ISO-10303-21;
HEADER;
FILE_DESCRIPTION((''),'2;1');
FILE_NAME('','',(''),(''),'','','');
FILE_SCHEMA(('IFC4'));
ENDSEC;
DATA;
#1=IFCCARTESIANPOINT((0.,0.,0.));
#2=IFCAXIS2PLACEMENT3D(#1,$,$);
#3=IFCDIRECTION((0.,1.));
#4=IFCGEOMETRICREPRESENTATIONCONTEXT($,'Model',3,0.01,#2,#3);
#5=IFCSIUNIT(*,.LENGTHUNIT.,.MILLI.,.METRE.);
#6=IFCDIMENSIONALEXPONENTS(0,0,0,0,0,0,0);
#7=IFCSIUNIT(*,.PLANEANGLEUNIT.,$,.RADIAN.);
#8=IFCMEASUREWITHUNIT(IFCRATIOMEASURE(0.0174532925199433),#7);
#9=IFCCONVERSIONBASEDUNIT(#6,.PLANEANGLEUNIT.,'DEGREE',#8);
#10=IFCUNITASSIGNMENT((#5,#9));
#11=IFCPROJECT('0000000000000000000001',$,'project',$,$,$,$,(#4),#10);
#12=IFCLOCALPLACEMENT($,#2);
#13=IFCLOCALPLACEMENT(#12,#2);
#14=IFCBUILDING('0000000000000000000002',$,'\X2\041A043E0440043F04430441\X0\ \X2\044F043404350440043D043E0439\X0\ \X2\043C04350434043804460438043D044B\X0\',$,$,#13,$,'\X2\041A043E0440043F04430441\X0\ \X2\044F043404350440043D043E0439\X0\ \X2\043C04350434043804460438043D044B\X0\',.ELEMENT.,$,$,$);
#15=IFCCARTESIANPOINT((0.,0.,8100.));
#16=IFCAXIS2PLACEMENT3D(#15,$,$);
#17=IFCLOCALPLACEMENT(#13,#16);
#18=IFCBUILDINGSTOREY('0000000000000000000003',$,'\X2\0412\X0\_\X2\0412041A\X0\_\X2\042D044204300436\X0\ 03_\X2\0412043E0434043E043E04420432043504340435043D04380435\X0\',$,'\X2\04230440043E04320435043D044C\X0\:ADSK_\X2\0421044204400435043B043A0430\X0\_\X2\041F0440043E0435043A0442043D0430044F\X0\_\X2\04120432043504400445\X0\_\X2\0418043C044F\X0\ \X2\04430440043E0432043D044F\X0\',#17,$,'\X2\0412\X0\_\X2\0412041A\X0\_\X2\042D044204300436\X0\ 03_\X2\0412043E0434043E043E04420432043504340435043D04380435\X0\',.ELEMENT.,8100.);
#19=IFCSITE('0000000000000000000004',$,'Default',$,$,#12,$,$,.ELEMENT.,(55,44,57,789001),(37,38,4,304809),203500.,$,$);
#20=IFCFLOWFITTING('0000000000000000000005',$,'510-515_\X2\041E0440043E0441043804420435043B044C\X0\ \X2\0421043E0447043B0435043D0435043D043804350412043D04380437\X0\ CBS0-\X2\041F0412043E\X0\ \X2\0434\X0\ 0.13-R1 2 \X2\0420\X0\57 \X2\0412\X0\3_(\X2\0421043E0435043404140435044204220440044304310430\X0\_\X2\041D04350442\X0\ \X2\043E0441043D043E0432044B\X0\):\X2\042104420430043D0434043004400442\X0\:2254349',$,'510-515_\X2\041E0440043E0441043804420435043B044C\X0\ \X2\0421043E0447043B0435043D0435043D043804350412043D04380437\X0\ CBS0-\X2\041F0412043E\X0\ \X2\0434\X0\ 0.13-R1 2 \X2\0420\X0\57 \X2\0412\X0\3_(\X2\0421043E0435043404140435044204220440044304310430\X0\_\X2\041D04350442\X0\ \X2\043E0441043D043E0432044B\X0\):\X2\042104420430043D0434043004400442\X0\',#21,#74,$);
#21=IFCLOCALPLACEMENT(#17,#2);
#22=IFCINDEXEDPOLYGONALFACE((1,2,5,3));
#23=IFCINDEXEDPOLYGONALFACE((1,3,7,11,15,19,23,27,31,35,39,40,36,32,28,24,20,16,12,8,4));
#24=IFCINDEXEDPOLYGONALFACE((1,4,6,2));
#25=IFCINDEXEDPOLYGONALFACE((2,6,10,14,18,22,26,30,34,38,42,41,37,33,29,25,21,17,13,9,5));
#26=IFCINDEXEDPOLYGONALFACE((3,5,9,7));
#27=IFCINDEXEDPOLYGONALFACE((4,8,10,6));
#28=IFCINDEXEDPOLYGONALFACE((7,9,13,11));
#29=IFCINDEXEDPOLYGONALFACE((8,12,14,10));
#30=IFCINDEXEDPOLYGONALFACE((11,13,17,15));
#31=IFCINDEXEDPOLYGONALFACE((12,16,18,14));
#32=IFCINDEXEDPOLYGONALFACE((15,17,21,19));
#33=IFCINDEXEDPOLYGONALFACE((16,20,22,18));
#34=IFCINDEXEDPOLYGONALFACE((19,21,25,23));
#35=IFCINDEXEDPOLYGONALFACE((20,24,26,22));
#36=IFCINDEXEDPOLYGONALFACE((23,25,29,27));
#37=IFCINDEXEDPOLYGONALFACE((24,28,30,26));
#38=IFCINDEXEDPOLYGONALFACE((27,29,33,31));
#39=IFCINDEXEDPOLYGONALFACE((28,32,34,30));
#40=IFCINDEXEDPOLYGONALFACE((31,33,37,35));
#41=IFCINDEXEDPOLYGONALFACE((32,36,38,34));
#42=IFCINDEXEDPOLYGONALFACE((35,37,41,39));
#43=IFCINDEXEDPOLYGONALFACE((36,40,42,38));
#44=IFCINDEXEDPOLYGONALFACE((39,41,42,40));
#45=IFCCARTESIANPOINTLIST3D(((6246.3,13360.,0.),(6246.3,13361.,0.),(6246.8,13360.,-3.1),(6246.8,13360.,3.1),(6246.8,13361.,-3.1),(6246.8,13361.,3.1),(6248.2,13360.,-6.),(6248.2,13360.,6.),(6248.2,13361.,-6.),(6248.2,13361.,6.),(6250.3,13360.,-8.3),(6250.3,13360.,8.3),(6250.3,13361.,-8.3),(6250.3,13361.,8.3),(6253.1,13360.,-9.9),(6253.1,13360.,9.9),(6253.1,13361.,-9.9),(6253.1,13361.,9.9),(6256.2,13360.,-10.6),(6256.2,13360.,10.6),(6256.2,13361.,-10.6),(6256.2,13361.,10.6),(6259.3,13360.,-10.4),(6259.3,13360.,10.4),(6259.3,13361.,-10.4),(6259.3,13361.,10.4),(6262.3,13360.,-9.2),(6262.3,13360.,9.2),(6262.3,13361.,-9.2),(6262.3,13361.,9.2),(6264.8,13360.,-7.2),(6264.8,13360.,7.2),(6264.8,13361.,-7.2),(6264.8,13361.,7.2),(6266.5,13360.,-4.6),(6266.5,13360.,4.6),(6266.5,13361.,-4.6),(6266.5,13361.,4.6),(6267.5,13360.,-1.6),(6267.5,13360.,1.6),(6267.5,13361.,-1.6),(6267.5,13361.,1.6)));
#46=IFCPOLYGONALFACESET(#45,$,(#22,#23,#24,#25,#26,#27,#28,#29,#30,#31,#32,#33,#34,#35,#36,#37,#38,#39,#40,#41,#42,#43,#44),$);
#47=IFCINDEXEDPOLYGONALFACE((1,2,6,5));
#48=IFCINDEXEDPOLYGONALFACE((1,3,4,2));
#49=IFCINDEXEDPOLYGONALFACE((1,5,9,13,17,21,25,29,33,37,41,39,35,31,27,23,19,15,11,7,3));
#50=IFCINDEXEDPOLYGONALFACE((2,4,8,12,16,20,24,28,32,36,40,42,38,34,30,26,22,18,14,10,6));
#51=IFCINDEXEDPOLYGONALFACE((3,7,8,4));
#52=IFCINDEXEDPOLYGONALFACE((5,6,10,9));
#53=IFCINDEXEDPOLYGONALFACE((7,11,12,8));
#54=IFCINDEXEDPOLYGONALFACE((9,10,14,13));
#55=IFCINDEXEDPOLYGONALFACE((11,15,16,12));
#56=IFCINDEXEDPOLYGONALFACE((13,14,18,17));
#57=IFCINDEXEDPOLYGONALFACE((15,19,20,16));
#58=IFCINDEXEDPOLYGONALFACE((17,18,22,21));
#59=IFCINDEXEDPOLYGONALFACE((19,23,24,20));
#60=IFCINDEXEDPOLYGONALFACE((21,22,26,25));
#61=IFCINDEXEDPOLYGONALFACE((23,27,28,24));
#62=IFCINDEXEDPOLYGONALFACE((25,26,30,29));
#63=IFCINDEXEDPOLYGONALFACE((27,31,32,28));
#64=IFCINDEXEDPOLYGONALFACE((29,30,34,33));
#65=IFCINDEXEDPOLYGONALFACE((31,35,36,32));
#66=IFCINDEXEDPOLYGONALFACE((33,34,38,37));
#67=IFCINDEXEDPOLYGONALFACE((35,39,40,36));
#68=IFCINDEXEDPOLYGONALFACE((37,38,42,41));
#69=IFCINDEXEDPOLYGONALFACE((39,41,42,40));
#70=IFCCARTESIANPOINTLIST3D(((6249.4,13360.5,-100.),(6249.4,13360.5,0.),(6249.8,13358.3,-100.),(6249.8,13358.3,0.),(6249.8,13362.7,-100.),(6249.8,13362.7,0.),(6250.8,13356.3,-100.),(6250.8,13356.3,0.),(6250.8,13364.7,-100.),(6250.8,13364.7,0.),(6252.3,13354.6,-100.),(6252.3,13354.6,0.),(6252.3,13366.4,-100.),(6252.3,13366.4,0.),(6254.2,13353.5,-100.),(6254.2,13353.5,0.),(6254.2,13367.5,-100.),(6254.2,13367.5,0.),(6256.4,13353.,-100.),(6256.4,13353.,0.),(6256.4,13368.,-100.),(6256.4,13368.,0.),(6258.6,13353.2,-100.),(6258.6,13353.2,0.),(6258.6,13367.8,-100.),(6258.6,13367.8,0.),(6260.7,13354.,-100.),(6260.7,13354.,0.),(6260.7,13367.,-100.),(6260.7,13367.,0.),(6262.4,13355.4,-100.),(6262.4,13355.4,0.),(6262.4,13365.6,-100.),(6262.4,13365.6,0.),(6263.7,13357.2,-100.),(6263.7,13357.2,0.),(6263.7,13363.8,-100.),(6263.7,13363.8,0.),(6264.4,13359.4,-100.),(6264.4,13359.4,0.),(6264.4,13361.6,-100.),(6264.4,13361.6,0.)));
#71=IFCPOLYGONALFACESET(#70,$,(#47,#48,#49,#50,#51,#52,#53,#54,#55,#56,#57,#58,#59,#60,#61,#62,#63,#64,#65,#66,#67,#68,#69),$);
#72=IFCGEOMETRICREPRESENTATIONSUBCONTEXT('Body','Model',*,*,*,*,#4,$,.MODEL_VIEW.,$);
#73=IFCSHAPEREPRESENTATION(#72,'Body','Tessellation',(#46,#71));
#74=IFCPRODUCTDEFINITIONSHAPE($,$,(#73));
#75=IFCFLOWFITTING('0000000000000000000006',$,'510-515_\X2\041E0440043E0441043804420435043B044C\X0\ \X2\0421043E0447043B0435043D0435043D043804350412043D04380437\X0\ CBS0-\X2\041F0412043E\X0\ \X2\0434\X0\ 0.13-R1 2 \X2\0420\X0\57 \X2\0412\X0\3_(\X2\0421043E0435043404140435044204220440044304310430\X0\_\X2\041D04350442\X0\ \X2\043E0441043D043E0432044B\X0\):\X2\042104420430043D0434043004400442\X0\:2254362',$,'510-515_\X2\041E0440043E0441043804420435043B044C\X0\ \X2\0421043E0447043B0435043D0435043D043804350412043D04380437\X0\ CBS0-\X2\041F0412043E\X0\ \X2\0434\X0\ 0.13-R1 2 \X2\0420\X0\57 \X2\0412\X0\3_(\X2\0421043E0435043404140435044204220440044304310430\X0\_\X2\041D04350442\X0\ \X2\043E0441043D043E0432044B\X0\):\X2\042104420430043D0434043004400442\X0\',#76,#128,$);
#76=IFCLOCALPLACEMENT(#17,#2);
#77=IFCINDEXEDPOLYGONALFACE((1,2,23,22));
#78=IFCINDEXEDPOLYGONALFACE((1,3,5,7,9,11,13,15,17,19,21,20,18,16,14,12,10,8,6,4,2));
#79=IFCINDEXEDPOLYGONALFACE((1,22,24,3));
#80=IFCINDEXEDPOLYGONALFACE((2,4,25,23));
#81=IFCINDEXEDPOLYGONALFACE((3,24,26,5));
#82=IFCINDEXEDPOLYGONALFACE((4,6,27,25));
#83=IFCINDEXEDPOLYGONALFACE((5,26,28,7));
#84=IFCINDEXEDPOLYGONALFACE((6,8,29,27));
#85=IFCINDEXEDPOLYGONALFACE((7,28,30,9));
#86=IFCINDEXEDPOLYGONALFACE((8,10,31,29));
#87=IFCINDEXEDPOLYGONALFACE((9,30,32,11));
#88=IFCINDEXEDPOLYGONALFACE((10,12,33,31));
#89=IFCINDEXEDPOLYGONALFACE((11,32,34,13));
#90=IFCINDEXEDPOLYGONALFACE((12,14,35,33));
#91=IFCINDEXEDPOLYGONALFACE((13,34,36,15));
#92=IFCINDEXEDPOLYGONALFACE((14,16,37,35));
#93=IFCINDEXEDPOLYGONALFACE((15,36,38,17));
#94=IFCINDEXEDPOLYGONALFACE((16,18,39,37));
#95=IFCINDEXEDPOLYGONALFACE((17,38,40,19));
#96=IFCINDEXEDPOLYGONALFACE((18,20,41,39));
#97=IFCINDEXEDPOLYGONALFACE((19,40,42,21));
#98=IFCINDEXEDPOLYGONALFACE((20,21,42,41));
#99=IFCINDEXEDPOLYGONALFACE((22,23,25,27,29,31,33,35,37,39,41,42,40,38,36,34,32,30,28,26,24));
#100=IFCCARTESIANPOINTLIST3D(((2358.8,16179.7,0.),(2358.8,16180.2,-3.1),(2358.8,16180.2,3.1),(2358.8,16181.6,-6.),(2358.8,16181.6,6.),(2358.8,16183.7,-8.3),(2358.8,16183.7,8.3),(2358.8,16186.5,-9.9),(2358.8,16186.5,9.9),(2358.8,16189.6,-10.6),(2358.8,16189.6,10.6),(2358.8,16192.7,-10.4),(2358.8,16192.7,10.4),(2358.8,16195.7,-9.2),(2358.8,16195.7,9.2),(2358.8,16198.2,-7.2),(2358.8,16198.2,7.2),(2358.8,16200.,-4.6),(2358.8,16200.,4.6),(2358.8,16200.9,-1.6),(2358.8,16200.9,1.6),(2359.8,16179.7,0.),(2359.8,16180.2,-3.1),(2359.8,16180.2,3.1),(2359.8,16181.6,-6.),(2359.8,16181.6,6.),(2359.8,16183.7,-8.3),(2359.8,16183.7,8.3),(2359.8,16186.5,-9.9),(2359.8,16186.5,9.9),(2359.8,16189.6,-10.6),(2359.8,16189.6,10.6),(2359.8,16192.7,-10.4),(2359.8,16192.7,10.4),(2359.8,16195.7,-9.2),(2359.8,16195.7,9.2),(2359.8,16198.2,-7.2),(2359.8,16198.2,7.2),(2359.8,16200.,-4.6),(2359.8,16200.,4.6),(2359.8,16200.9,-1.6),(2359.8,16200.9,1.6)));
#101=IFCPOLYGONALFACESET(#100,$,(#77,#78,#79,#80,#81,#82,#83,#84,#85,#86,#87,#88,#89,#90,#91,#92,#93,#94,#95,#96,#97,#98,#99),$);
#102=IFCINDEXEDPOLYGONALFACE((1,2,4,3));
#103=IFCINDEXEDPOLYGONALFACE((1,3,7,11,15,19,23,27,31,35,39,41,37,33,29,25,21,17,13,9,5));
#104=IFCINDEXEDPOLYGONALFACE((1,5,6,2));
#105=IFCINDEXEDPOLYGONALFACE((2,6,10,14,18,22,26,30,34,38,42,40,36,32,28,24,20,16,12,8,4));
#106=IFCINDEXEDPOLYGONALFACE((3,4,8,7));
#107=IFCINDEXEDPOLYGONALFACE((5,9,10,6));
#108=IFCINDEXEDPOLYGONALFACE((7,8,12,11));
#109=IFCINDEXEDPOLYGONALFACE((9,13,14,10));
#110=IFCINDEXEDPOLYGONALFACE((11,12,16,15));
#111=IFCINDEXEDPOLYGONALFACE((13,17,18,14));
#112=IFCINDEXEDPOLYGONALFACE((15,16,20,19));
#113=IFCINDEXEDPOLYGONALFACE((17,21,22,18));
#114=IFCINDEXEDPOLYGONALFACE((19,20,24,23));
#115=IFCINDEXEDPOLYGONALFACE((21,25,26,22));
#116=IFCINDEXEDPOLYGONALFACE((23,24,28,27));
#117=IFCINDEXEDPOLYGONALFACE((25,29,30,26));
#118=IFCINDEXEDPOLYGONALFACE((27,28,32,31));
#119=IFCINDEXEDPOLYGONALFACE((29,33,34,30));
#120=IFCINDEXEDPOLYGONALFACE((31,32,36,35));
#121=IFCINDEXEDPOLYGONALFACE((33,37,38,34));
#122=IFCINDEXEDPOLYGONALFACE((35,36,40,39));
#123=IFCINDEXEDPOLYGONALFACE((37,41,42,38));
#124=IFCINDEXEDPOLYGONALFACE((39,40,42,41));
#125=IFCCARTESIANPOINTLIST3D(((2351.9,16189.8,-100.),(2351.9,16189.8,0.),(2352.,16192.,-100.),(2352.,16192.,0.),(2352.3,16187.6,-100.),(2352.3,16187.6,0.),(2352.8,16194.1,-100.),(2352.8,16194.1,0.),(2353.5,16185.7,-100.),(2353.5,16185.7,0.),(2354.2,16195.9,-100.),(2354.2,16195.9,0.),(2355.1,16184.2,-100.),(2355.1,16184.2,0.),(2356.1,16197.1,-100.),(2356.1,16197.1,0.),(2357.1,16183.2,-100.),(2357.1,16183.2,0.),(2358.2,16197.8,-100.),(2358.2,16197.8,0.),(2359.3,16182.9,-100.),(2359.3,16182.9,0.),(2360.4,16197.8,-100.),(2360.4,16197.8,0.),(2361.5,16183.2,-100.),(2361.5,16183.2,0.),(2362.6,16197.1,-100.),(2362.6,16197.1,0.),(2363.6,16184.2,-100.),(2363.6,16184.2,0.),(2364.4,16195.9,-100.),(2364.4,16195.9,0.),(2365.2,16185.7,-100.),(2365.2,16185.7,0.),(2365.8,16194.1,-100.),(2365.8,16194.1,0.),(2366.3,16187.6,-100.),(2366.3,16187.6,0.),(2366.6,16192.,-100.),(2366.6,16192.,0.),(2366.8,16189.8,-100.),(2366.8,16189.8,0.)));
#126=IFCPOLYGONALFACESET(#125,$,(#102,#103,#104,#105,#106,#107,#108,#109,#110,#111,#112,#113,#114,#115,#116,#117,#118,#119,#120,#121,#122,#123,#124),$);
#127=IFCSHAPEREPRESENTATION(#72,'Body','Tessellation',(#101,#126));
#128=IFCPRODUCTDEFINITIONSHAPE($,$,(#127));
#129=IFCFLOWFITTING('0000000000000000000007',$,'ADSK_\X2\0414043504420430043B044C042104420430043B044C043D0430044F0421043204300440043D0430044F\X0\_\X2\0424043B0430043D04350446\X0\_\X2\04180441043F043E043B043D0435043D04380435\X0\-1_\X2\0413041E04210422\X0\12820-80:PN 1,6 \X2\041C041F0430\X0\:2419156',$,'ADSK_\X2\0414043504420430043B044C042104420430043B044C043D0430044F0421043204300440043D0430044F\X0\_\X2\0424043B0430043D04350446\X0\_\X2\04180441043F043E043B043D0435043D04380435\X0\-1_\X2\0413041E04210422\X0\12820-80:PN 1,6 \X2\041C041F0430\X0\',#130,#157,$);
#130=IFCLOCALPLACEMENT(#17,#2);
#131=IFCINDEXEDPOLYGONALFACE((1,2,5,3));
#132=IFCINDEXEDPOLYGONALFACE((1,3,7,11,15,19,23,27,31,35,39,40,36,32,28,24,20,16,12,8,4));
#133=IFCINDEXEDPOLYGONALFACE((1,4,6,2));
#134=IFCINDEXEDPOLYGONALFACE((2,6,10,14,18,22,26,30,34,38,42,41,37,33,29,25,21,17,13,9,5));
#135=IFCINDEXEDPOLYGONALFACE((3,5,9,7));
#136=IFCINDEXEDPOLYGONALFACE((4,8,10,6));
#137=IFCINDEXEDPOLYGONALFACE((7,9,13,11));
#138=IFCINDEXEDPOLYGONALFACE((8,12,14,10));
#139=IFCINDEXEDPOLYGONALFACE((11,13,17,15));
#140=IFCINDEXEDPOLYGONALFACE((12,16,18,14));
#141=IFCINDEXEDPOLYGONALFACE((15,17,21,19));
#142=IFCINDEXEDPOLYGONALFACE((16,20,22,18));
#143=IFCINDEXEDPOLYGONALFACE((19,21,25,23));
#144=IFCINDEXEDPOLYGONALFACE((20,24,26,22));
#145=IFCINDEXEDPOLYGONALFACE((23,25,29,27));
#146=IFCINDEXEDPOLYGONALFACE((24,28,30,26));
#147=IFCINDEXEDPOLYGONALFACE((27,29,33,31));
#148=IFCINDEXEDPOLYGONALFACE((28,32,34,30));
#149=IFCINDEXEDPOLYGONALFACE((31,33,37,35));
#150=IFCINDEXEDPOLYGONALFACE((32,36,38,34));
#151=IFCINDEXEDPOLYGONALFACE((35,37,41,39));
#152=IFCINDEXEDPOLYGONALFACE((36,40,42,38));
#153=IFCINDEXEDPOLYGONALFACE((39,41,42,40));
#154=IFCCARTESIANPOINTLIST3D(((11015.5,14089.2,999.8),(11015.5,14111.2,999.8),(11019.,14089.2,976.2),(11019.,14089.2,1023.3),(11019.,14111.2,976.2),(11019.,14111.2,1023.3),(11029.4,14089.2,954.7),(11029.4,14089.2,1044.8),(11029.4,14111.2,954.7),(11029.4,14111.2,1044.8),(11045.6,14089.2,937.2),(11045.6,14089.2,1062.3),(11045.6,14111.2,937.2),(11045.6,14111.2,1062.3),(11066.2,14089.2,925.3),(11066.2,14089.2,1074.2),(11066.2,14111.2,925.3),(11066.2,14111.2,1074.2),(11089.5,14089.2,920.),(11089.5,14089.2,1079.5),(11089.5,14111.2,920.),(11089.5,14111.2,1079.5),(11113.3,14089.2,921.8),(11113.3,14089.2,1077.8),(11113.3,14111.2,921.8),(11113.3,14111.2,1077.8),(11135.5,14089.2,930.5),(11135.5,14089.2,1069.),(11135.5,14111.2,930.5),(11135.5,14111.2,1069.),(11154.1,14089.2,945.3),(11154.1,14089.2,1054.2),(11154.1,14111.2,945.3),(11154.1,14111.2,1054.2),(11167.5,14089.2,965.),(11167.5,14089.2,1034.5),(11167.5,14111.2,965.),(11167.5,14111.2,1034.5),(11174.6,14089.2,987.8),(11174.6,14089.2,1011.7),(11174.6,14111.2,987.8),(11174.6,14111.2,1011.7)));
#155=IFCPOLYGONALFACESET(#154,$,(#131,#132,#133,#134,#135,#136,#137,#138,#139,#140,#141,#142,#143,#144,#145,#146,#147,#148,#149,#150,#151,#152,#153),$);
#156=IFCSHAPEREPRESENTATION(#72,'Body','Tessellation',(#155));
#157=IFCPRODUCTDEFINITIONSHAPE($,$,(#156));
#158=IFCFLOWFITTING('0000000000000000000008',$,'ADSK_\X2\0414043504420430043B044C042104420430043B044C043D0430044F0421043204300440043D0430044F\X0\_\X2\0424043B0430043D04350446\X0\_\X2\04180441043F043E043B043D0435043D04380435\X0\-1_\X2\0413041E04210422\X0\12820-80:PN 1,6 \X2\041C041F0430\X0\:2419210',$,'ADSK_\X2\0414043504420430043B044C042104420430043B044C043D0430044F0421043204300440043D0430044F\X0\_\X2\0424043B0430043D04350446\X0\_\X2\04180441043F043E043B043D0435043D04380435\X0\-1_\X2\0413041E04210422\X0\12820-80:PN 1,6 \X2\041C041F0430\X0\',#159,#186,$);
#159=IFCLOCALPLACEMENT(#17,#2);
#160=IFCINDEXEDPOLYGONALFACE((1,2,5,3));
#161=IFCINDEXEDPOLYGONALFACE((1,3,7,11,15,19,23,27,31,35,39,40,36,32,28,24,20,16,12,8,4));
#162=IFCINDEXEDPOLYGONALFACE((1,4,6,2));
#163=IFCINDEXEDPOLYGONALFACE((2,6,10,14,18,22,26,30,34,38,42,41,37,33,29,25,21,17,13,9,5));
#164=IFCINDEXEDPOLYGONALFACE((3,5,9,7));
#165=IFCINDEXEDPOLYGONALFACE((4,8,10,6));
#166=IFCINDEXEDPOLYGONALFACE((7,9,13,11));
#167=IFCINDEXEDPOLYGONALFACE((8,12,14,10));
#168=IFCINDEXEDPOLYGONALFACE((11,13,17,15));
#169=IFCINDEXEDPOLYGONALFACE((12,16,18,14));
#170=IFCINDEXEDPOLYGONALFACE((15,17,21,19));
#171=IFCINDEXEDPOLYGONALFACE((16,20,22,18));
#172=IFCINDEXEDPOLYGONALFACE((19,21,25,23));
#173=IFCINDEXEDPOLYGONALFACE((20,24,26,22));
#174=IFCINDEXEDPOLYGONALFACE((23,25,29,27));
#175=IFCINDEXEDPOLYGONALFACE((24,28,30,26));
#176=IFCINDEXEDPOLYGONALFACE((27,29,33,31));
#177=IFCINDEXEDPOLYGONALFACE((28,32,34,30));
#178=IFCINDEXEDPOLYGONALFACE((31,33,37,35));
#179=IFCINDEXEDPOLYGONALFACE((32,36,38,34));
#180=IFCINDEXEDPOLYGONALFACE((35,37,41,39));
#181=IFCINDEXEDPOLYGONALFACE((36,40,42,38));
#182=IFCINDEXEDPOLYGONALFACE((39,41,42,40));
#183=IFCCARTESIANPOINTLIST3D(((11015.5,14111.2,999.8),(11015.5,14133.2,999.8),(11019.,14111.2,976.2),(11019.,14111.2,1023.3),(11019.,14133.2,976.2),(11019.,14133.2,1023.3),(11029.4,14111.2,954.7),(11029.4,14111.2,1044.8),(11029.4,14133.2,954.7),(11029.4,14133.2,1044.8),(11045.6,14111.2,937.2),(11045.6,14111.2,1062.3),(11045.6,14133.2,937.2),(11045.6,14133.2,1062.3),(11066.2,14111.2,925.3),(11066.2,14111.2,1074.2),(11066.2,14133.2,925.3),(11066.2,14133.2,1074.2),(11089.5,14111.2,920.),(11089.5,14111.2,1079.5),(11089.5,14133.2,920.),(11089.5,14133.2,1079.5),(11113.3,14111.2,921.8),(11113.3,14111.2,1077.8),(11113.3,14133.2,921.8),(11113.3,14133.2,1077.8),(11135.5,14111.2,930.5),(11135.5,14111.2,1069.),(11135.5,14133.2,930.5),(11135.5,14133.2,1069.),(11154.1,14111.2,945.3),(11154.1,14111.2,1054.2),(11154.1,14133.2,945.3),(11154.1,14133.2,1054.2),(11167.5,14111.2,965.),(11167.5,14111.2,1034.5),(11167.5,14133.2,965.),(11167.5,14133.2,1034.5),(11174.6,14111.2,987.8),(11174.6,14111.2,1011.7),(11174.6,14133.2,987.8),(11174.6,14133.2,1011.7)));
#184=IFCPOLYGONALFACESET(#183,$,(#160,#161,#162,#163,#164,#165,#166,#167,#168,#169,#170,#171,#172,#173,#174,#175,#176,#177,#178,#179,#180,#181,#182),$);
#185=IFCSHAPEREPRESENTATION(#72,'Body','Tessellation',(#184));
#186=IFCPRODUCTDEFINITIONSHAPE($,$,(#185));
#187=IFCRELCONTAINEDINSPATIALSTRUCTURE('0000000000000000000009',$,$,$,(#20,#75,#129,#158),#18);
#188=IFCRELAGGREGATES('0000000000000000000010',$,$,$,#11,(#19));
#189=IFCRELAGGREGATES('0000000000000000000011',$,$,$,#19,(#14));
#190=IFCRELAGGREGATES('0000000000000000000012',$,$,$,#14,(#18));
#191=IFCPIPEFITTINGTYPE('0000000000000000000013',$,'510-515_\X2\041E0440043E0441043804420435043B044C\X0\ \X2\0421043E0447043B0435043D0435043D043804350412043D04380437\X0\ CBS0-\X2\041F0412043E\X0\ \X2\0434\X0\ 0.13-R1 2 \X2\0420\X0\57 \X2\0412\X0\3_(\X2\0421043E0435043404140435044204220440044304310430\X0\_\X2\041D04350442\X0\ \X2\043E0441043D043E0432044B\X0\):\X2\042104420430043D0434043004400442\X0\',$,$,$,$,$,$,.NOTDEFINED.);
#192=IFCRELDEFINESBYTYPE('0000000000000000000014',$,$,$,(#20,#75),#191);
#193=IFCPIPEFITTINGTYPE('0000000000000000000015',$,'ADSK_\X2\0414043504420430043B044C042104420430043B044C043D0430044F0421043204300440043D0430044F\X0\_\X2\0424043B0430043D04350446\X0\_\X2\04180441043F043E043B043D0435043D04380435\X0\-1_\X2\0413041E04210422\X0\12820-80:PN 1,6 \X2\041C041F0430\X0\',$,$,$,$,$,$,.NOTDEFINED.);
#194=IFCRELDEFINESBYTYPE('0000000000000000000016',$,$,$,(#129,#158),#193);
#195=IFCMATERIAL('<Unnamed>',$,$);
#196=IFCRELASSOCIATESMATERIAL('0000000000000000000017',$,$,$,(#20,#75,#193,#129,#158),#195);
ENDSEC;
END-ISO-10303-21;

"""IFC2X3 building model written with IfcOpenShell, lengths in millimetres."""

from ifc_helpers import new_model, entity, si_unit, converted_unit, direction, frame, origin, origin_2d_with_axis, place, context, subcontext, project, spatial, circle, extrude, source, transform, mapped, material, type_object, type_shapes, element, save


model = new_model("IFC2X3")

# Units and contexts
model_context = context("Model", 3, precision=0.01, world=origin(), true_north=direction((0.0, 1.0)))
body_context = subcontext(model_context, "Body", "Model", "MODEL_VIEW")
ifc_project = project(units=[si_unit("LENGTHUNIT", "METRE", prefix="MILLI"), converted_unit("PLANEANGLEUNIT", "DEGREE", entity("IfcRatioMeasure", 0.0174532925199433), si_unit("PLANEANGLEUNIT", "RADIAN"), dimensions=[0, 0, 0, 0, 0, 0, 0])], contexts=[model_context])

# Site, building, storey
site_placement = place(None, origin())
site = spatial("IfcSite", under=ifc_project, at=site_placement, Name="Default", CompositionType="ELEMENT", RefLatitude=(55, 44, 57, 789001), RefLongitude=(37, 38, 4, 304809), RefElevation=203500.0)
building_placement = place(site_placement, origin())
building = spatial("IfcBuilding", under=site, at=building_placement, Name="Корпус ядерной медицины", LongName="Корпус ядерной медицины", CompositionType="ELEMENT")
storey_placement = place(building_placement, frame((0.0, 0.0, 8100.0)))
storey = spatial("IfcBuildingStorey", under=building, at=storey_placement, Name="В_ВК_Этаж 03_Водоотведение", ObjectType="Уровень:ADSK_Стрелка_Проектная_Вверх_Имя уровня", LongName="В_ВК_Этаж 03_Водоотведение", CompositionType="ELEMENT", Elevation=8100.0)

# Flow fittings
ifc_material_1 = material(Name="<Unnamed>")
pipe_fitting_type_1 = type_object("IfcPipeFittingType", Name="510-515_Ороситель СочленениеВниз CBS0-ПВо д 0.13-R1 2 Р57 В3_(СоедДетТруба_Нет основы):Стандарт", PredefinedType="NOTDEFINED")
shared_shape_1 = source(origin(), body_context, "Body", "SweptSolid", [
    extrude(circle(Radius=10.7, at=origin_2d_with_axis()), frame((-0.5, 0.0, 0.0), z_axis=(1.0, 0.0, 0.0), x_axis=(0.0, 1.0, 0.0)), (0.0, 0.0, 1.0), 1.0),
    extrude(circle(Radius=7.5, at=origin_2d_with_axis()), frame((0.0, 0.0, -100.0), z_axis=(0.0, 0.0, 1.0), x_axis=(0.0, 1.0, 0.0)), (0.0, 0.0, 1.0), 100.0),
])
type_shapes(pipe_fitting_type_1, [shared_shape_1])
for number, where, z_axis, x_axis, name in (
    (1, (6256.9, 13360.5, 0.0), (0.0, 0.0, 1.0), (0.0, 1.0, 0.0), "510-515_Ороситель СочленениеВниз CBS0-ПВо д 0.13-R1 2 Р57 В3_(СоедДетТруба_Нет основы):Стандарт:2254349"),
    (2, (2359.3, 16190.4, 0.0), (0.0, 0.0, 1.0), (-1.0, 0.0, 0.0), "510-515_Ороситель СочленениеВниз CBS0-ПВо д 0.13-R1 2 Р57 В3_(СоедДетТруба_Нет основы):Стандарт:2254362"),
):
    element("IfcFlowFitting", number, at=place(storey_placement, frame(where, z_axis=z_axis, x_axis=x_axis)), inside=storey, type_object=pipe_fitting_type_1, material=ifc_material_1, Name=name, ObjectType="510-515_Ороситель СочленениеВниз CBS0-ПВо д 0.13-R1 2 Р57 В3_(СоедДетТруба_Нет основы):Стандарт", context=body_context, shape_type="MappedRepresentation", body=[
        mapped(shared_shape_1, transform((0.0, 0.0, 0.0), scale=1.0)),
    ])
pipe_fitting_type_2 = type_object("IfcPipeFittingType", Name="ADSK_ДетальСтальнаяСварная_Фланец_Исполнение-1_ГОСТ12820-80:PN 1,6 МПа", PredefinedType="NOTDEFINED", material=ifc_material_1)
shared_shape_2 = source(origin(), body_context, "Body", "SweptSolid", [
    extrude(circle(Radius=80.0, at=origin_2d_with_axis()), frame((0.0, 0.0, 0.0), z_axis=(1.0, 0.0, 0.0), x_axis=(0.0, 1.0, 0.0)), (0.0, 0.0, 1.0), 22.0),
])
type_shapes(pipe_fitting_type_2, [shared_shape_2])
for number, where, z_axis, x_axis, name in (
    (3, (11095.5, 14089.2, 999.8), (0.0, 0.0, 1.0), (0.0, 1.0, 0.0), "ADSK_ДетальСтальнаяСварная_Фланец_Исполнение-1_ГОСТ12820-80:PN 1,6 МПа:2419156"),
    (4, (11095.5, 14111.2, 999.8), (0.0, 0.0, 1.0), (0.0, 1.0, 0.0), "ADSK_ДетальСтальнаяСварная_Фланец_Исполнение-1_ГОСТ12820-80:PN 1,6 МПа:2419210"),
):
    element("IfcFlowFitting", number, at=place(storey_placement, frame(where, z_axis=z_axis, x_axis=x_axis)), inside=storey, type_object=pipe_fitting_type_2, material=ifc_material_1, Name=name, ObjectType="ADSK_ДетальСтальнаяСварная_Фланец_Исполнение-1_ГОСТ12820-80:PN 1,6 МПа", context=body_context, shape_type="MappedRepresentation", body=[
        mapped(shared_shape_2, transform((0.0, 0.0, 0.0), scale=1.0)),
    ])

save(model, "model.ifc")
